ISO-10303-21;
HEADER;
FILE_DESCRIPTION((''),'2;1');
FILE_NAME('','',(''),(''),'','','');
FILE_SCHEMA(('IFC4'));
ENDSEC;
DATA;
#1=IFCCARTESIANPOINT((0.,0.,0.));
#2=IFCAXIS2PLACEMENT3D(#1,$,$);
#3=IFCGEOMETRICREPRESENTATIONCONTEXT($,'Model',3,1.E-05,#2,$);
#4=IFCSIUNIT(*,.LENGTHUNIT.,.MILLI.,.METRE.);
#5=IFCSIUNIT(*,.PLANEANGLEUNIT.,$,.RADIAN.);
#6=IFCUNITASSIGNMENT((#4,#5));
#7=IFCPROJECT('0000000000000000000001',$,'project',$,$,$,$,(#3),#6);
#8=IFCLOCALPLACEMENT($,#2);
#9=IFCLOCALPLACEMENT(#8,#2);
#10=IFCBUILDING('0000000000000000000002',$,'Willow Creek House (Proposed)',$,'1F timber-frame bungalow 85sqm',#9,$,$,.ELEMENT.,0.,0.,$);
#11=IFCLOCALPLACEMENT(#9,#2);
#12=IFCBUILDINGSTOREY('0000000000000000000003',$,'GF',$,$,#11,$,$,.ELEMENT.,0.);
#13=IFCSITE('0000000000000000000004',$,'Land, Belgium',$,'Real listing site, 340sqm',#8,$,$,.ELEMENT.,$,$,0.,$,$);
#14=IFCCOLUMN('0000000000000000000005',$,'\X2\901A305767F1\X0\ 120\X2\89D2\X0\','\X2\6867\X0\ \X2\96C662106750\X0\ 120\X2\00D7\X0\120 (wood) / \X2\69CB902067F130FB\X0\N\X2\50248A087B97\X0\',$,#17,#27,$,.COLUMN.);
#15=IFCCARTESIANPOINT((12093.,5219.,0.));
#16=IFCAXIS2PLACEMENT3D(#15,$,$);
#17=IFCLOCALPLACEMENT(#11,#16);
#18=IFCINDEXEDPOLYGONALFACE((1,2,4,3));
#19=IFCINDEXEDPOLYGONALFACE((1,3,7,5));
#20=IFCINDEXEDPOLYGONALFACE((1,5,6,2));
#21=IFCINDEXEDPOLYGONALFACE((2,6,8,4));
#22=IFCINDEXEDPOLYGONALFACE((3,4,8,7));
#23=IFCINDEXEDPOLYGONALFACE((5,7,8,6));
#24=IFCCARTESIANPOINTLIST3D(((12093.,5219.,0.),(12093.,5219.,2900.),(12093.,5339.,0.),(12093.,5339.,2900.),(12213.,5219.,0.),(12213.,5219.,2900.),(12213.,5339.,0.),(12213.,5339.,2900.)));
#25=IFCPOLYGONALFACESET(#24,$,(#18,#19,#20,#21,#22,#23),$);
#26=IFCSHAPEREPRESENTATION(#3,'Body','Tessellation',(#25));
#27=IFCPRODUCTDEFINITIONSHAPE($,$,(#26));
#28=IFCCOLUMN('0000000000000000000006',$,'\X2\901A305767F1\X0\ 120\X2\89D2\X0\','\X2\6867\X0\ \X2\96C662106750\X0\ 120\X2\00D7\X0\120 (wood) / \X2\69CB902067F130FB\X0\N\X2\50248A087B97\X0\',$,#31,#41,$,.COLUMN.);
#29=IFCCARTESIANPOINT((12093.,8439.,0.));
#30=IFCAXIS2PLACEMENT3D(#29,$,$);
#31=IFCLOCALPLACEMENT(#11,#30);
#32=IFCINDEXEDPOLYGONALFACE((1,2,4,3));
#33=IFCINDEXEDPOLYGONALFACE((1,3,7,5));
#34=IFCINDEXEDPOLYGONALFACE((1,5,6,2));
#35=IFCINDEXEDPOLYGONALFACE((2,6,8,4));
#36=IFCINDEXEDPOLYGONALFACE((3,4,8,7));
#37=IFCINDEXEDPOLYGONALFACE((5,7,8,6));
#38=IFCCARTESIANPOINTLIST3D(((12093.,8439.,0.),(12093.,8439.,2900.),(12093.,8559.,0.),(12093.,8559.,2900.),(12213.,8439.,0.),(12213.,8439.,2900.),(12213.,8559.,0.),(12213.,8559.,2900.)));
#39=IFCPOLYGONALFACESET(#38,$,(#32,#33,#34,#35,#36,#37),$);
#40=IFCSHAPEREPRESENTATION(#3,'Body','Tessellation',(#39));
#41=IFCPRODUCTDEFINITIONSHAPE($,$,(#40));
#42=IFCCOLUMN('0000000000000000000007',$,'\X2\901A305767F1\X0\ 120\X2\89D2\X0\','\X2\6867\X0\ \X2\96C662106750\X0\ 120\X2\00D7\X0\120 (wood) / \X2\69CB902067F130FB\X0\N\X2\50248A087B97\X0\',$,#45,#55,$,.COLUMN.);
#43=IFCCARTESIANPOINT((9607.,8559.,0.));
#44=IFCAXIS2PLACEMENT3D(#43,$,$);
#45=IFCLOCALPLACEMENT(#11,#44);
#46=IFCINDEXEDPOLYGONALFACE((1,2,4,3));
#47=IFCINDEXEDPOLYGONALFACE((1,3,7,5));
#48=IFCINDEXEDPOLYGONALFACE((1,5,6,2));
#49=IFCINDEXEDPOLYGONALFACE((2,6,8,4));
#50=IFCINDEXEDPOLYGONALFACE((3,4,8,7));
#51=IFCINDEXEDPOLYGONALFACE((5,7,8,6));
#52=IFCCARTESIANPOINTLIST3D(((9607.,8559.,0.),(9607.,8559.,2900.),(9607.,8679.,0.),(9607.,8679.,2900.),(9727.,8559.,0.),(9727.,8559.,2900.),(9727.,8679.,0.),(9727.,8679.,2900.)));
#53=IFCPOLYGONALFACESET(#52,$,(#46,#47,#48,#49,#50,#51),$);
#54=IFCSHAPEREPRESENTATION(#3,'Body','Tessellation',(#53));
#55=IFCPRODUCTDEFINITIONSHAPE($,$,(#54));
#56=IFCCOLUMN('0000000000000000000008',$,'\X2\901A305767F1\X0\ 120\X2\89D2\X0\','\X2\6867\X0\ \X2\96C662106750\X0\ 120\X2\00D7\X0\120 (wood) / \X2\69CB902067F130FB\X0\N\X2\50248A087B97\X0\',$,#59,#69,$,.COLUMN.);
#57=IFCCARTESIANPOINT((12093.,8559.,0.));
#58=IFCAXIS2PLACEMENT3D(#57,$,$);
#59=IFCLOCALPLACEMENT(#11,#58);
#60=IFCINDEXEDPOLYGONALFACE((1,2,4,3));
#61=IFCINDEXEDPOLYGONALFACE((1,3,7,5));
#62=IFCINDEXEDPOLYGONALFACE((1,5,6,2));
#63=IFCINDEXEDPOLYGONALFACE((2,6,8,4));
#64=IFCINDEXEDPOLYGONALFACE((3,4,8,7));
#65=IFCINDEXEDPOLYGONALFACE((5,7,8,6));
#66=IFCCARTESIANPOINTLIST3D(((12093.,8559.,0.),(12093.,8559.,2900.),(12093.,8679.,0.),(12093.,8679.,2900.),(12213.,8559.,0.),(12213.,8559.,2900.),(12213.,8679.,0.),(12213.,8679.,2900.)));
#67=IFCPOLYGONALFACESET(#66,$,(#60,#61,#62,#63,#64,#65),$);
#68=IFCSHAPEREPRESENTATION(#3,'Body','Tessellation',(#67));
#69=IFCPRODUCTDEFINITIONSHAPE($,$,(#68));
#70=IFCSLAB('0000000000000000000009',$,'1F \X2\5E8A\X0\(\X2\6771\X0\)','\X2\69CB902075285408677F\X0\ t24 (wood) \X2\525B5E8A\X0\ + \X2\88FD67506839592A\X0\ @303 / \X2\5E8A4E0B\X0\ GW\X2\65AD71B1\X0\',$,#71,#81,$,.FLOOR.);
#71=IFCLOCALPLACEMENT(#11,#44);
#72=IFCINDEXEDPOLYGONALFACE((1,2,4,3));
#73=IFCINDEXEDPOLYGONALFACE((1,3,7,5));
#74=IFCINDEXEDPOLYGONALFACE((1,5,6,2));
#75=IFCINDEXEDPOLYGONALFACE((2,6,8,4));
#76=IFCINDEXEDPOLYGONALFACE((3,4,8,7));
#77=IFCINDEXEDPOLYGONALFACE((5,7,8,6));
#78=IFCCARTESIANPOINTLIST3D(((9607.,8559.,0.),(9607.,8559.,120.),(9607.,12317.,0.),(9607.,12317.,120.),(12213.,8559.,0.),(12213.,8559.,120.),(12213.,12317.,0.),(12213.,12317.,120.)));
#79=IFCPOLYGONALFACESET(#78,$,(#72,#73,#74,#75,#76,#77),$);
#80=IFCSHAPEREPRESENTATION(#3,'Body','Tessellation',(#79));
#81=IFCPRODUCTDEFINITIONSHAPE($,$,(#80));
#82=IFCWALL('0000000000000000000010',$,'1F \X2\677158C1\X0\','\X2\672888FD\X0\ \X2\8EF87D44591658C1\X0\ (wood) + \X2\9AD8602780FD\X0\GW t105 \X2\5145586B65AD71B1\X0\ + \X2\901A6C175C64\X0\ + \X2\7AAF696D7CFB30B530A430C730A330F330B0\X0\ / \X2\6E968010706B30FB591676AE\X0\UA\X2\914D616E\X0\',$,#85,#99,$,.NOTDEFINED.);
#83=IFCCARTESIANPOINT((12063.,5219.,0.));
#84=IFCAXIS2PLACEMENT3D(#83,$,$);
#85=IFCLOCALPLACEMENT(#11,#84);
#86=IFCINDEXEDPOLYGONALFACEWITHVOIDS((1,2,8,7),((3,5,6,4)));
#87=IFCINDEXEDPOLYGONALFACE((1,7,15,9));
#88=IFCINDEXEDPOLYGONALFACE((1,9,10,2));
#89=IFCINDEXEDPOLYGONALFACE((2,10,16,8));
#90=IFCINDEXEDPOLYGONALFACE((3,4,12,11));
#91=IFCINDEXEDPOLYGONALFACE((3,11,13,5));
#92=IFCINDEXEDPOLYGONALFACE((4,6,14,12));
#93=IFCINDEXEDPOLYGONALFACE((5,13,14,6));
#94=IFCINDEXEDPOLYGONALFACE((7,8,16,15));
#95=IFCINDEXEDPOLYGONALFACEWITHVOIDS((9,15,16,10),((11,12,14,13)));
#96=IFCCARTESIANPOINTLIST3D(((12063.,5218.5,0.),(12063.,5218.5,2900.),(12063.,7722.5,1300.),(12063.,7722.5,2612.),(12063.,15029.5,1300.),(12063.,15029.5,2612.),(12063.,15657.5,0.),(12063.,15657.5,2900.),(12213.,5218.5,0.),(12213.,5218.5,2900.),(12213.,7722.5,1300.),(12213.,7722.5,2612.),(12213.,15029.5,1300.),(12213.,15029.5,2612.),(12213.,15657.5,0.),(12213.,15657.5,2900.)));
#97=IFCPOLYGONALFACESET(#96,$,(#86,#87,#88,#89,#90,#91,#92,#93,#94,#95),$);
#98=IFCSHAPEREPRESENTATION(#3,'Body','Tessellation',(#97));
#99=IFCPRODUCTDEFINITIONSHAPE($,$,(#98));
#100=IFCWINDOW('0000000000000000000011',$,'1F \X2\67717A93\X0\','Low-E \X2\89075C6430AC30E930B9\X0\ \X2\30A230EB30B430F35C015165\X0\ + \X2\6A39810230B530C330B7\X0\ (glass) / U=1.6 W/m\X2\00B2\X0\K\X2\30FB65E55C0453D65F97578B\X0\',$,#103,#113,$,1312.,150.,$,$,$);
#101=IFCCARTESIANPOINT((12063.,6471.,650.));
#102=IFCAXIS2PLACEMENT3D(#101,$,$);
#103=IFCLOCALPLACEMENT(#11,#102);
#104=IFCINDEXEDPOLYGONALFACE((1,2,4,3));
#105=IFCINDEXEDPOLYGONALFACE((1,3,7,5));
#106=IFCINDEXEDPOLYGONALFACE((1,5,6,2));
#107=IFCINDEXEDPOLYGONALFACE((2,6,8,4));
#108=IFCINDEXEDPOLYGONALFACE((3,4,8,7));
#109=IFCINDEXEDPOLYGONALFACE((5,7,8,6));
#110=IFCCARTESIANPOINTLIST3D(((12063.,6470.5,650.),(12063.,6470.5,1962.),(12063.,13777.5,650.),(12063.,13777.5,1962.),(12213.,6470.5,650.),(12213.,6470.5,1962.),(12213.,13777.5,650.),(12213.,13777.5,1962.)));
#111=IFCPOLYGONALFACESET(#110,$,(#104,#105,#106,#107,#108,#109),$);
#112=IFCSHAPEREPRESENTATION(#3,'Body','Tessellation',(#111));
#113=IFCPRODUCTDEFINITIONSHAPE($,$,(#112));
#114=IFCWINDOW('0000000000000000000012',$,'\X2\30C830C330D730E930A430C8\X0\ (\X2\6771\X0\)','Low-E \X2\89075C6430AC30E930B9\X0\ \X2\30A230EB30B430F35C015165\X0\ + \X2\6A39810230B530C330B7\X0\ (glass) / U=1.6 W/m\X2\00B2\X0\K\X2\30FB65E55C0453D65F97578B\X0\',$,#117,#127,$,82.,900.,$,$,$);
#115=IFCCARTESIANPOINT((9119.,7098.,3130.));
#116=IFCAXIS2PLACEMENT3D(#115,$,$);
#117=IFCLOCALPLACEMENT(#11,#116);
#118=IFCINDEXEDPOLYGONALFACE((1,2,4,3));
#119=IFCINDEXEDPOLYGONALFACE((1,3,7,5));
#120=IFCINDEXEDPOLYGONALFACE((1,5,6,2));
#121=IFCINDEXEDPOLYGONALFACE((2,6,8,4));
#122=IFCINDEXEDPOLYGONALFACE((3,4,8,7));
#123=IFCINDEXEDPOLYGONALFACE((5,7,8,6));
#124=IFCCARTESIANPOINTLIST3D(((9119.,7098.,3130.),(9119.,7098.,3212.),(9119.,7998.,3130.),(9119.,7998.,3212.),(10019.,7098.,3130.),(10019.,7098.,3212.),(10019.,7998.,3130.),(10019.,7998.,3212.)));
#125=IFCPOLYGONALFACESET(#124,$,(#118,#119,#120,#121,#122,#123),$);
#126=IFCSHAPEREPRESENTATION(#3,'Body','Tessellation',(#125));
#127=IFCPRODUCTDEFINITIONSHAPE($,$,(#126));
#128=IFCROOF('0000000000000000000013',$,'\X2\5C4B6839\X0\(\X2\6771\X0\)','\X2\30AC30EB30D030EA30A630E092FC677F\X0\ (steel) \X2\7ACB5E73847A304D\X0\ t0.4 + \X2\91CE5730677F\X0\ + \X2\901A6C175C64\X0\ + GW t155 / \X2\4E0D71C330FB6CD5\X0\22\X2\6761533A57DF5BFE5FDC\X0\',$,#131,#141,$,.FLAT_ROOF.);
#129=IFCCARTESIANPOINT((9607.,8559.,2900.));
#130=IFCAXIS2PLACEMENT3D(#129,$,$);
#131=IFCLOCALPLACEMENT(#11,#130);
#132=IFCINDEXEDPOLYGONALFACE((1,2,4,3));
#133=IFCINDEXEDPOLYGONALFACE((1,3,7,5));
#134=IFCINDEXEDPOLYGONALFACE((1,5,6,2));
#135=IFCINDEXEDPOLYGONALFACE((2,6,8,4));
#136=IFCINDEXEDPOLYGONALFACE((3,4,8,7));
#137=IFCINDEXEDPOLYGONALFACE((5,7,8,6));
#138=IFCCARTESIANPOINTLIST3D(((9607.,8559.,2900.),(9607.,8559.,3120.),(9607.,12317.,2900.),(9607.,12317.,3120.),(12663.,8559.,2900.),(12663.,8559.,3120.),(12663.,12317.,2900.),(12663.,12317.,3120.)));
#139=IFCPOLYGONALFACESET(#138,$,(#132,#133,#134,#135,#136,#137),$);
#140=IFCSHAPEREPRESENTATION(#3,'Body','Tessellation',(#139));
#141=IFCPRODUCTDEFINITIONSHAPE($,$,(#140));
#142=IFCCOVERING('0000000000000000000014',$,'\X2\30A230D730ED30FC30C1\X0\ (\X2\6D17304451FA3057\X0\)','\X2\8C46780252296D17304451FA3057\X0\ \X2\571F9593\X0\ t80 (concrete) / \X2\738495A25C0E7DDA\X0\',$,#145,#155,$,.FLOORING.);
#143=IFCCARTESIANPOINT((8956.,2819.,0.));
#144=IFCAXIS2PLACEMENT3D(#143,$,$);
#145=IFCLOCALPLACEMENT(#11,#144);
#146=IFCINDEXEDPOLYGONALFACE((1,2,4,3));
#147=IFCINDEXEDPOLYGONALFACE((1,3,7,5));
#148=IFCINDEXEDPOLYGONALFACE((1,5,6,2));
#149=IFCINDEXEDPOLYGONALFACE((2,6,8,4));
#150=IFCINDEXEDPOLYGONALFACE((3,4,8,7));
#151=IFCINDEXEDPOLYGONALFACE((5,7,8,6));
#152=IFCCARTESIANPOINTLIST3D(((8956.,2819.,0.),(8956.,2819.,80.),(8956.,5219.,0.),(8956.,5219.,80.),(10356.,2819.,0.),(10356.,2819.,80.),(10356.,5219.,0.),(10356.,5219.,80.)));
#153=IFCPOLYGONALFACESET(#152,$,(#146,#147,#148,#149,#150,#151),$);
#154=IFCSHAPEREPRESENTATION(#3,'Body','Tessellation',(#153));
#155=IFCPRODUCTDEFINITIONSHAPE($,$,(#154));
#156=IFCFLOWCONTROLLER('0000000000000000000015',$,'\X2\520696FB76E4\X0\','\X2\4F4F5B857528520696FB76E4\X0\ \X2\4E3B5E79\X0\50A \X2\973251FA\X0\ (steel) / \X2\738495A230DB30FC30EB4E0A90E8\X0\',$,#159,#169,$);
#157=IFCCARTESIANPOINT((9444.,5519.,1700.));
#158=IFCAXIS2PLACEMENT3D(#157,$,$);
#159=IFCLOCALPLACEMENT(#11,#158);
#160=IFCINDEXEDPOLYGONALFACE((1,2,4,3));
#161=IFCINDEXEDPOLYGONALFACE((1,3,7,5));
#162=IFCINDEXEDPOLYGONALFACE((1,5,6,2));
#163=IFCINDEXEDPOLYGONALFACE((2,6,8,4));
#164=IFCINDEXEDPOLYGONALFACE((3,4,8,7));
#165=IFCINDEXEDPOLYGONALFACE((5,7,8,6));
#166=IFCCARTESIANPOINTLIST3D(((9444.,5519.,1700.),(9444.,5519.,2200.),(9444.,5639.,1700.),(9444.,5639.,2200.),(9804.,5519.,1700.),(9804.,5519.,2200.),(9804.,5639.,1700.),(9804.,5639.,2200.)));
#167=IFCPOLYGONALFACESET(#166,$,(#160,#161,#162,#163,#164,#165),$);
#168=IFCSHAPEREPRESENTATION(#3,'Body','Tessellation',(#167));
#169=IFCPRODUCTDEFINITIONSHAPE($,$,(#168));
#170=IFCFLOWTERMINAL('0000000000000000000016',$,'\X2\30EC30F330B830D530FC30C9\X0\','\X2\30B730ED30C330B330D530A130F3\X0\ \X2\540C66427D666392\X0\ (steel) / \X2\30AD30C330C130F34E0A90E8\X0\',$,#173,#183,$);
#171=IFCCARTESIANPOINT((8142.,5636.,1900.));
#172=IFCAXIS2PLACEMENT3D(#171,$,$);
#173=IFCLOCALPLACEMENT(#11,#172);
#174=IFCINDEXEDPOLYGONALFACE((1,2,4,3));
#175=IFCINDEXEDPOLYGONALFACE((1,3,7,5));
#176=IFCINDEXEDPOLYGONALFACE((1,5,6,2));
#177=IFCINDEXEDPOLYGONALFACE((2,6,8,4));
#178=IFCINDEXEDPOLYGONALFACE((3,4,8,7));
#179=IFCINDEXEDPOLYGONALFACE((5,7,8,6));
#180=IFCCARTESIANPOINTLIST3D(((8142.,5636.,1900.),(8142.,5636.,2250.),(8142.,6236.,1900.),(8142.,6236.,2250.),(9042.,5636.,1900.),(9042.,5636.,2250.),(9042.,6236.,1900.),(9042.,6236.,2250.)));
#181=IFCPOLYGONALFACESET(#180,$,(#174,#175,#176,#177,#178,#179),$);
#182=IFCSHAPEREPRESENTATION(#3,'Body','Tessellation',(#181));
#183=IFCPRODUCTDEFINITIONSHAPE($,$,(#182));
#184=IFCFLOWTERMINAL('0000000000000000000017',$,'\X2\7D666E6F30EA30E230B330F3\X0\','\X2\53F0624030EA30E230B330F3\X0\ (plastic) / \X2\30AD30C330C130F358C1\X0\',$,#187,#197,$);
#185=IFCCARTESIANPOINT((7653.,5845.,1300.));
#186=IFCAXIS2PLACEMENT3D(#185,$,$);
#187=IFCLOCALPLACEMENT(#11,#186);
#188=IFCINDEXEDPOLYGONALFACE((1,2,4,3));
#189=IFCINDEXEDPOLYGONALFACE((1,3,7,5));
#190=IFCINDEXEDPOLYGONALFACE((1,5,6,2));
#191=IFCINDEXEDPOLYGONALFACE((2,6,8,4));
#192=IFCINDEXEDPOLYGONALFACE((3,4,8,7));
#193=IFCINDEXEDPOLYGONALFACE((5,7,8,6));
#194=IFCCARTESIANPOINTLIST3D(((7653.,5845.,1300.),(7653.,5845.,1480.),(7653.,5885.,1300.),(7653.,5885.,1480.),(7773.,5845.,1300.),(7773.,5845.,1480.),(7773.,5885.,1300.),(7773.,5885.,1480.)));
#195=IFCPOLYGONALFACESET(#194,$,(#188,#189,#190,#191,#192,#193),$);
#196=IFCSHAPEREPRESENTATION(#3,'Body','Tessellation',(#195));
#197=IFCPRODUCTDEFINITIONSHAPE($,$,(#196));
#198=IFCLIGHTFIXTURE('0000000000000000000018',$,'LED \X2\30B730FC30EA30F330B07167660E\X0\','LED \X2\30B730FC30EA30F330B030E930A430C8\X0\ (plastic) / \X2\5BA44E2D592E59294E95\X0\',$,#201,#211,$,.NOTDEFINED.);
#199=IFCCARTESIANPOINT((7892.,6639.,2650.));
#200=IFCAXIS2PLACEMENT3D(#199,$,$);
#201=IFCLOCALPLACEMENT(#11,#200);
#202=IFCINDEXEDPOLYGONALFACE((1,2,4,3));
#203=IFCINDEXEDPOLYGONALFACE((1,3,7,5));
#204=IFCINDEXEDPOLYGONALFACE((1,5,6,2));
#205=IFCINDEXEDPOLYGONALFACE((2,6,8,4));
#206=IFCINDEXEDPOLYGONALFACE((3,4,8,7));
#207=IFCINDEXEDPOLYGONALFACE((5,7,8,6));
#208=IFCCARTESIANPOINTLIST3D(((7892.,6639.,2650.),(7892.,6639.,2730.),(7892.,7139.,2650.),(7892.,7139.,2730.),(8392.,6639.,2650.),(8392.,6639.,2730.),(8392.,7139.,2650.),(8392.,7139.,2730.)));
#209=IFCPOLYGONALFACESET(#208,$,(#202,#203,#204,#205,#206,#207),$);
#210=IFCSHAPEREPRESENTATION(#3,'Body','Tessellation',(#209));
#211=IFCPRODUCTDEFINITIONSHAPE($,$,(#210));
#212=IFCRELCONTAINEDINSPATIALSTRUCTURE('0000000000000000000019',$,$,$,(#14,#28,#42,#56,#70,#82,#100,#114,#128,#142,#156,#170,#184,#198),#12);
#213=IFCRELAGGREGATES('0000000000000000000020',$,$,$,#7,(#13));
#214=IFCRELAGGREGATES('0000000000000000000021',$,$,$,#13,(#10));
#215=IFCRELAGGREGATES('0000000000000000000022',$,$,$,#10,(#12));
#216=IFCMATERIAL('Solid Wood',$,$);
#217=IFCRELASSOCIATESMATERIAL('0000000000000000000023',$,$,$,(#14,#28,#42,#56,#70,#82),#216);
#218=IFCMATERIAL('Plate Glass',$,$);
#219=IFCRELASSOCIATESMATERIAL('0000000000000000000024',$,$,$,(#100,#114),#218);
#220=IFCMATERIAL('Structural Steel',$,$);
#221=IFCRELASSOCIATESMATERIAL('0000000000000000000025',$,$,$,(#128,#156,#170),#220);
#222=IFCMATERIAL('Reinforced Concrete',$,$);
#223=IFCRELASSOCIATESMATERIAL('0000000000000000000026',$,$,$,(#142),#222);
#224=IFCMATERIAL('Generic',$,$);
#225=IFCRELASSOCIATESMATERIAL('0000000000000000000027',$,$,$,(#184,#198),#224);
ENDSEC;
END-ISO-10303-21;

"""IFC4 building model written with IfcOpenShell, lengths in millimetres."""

from ifc_helpers import new_model, si_unit, frame, frame_2d, origin, place, context, project, spatial, rectangle, extrude, material, element, fill, save


model = new_model("IFC4")

# Units and contexts
model_context = context("Model", 3, precision=1e-05, world=origin())
ifc_project = project(units=[si_unit("LENGTHUNIT", "METRE", prefix="MILLI"), si_unit("PLANEANGLEUNIT", "RADIAN")], contexts=[model_context])

# Site, building, storey
site_placement = place(None, origin())
site = spatial("IfcSite", under=ifc_project, at=site_placement, Name="Land, Belgium", ObjectType="Real listing site, 340sqm", CompositionType="ELEMENT", RefElevation=0.0)
building_placement = place(site_placement, origin())
building = spatial("IfcBuilding", under=site, at=building_placement, Name="Willow Creek House (Proposed)", ObjectType="1F timber-frame bungalow 85sqm", CompositionType="ELEMENT", ElevationOfRefHeight=0.0, ElevationOfTerrain=0.0)
storey_placement = place(building_placement, origin())
storey = spatial("IfcBuildingStorey", under=building, at=storey_placement, Name="GF", CompositionType="ELEMENT", Elevation=0.0)

# Columns
ifc_material_1 = material(Name="Solid Wood")
column_1_placement = place(storey_placement, frame((12093.0, 5219.0, 0.0)))
element("IfcColumn", 1, at=column_1_placement, inside=storey, material=ifc_material_1, Name="通し柱 120角", Description="桧 集成材 120×120 (wood) / 構造柱・N値計算", PredefinedType="COLUMN", context=model_context, shape_type="SweptSolid", body=[
    extrude(rectangle(XDim=120.0, YDim=120.0, at=frame_2d((60.0, 60.0))), frame((12093.0, 5219.0, 0.0)), (0.0, 0.0, 1.0), 2900.0),
])
column_2_placement = place(storey_placement, frame((12093.0, 8439.0, 0.0)))
element("IfcColumn", 2, at=column_2_placement, inside=storey, material=ifc_material_1, Name="通し柱 120角", Description="桧 集成材 120×120 (wood) / 構造柱・N値計算", PredefinedType="COLUMN", context=model_context, shape_type="SweptSolid", body=[
    extrude(rectangle(XDim=120.0, YDim=120.0, at=frame_2d((60.0, 60.0))), frame((12093.0, 8439.0, 0.0)), (0.0, 0.0, 1.0), 2900.0),
])
column_3_placement = place(storey_placement, frame((9607.0, 8559.0, 0.0)))
element("IfcColumn", 3, at=column_3_placement, inside=storey, material=ifc_material_1, Name="通し柱 120角", Description="桧 集成材 120×120 (wood) / 構造柱・N値計算", PredefinedType="COLUMN", context=model_context, shape_type="SweptSolid", body=[
    extrude(rectangle(XDim=120.0, YDim=120.0, at=frame_2d((60.0, 60.0))), frame((9607.0, 8559.0, 0.0)), (0.0, 0.0, 1.0), 2900.0),
])
column_4_placement = place(storey_placement, frame((12093.0, 8559.0, 0.0)))
element("IfcColumn", 4, at=column_4_placement, inside=storey, material=ifc_material_1, Name="通し柱 120角", Description="桧 集成材 120×120 (wood) / 構造柱・N値計算", PredefinedType="COLUMN", context=model_context, shape_type="SweptSolid", body=[
    extrude(rectangle(XDim=120.0, YDim=120.0, at=frame_2d((60.0, 60.0))), frame((12093.0, 8559.0, 0.0)), (0.0, 0.0, 1.0), 2900.0),
])

# Slab
slab_placement = place(storey_placement, frame((9607.0, 8559.0, 0.0)))
element("IfcSlab", 5, at=slab_placement, inside=storey, material=ifc_material_1, Name="1F 床(東)", Description="構造用合板 t24 (wood) 剛床 + 製材根太 @303 / 床下 GW断熱", PredefinedType="FLOOR", context=model_context, shape_type="SweptSolid", body=[
    extrude(rectangle(XDim=2606.0, YDim=3758.0, at=frame_2d((1303.0, 1879.0))), frame((9607.0, 8559.0, 0.0)), (0.0, 0.0, 1.0), 120.0),
])

# Wall, opening, window
wall_1_placement = place(storey_placement, frame((12063.0, 5219.0, 0.0)))
wall_1 = element("IfcWall", 6, at=wall_1_placement, inside=storey, material=ifc_material_1, Name="1F 東壁", Description="木製 軸組外壁 (wood) + 高性能GW t105 充填断熱 + 通気層 + 窯業系サイディング / 準耐火・外皮UA配慮", PredefinedType="NOTDEFINED", context=model_context, shape_type="SweptSolid", body=[
    extrude(rectangle(XDim=150.0, YDim=10439.0, at=frame_2d((75.0, 5219.0))), frame((12063.0, 5219.0, 0.0)), (0.0, 0.0, 1.0), 2900.0),
])
opening_placement = place(storey_placement, frame((12063.0, 6471.0, 650.0)))
opening = element("IfcOpeningElement", 7, at=opening_placement, cuts=wall_1, PredefinedType="NOTDEFINED", context=model_context, shape_type="SweptSolid", body=[
    extrude(rectangle(XDim=150.0, YDim=7307.0, at=frame_2d((75.0, 3653.0))), frame((12063.0, 6471.0, 650.0)), (0.0, 0.0, 1.0), 1312.0),
])
ifc_material_2 = material(Name="Plate Glass")
window_1_placement = place(storey_placement, frame((12063.0, 6471.0, 650.0)))
window_1 = element("IfcWindow", 8, at=window_1_placement, inside=storey, material=ifc_material_2, Name="1F 東窓", Description="Low-E 複層ガラス アルゴン封入 + 樹脂サッシ (glass) / U=1.6 W/m²K・日射取得型", OverallHeight=1312.0, OverallWidth=150.0, context=model_context, shape_type="SweptSolid", body=[
    extrude(rectangle(XDim=150.0, YDim=7307.0, at=frame_2d((75.0, 3653.0))), frame((12063.0, 6471.0, 650.0)), (0.0, 0.0, 1.0), 1312.0),
])
fill(opening, window_1)

# Window
window_2_placement = place(storey_placement, frame((9119.0, 7098.0, 3130.0)))
element("IfcWindow", 9, at=window_2_placement, inside=storey, material=ifc_material_2, Name="トップライト (東)", Description="Low-E 複層ガラス アルゴン封入 + 樹脂サッシ (glass) / U=1.6 W/m²K・日射取得型", OverallHeight=82.0, OverallWidth=900.0, context=model_context, shape_type="SweptSolid", body=[
    extrude(rectangle(XDim=900.0, YDim=900.0, at=frame_2d((450.0, 450.0))), frame((9119.0, 7098.0, 3130.0)), (0.0, 0.0, 1.0), 82.0),
])

# Roof
ifc_material_3 = material(Name="Structural Steel")
roof_placement = place(storey_placement, frame((9607.0, 8559.0, 2900.0)))
element("IfcRoof", 10, at=roof_placement, inside=storey, material=ifc_material_3, Name="屋根(東)", Description="ガルバリウム鋼板 (steel) 立平葺き t0.4 + 野地板 + 通気層 + GW t155 / 不燃・法22条区域対応", PredefinedType="FLAT_ROOF", context=model_context, shape_type="SweptSolid", body=[
    extrude(rectangle(XDim=3056.0, YDim=3758.0, at=frame_2d((1528.0, 1879.0))), frame((9607.0, 8559.0, 2900.0)), (0.0, 0.0, 1.0), 220.0),
])

# Covering
ifc_material_4 = material(Name="Reinforced Concrete")
covering_placement = place(storey_placement, frame((8956.0, 2819.0, 0.0)))
element("IfcCovering", 11, at=covering_placement, inside=storey, material=ifc_material_4, Name="アプローチ (洗い出し)", Description="豆砂利洗い出し 土間 t80 (concrete) / 玄関導線", PredefinedType="FLOORING", context=model_context, shape_type="SweptSolid", body=[
    extrude(rectangle(XDim=1400.0, YDim=2400.0, at=frame_2d((700.0, 1200.0))), frame((8956.0, 2819.0, 0.0)), (0.0, 0.0, 1.0), 80.0),
])

# Flow controller
flow_controller_placement = place(storey_placement, frame((9444.0, 5519.0, 1700.0)))
element("IfcFlowController", 12, at=flow_controller_placement, inside=storey, material=ifc_material_3, Name="分電盤", Description="住宅用分電盤 主幹50A 露出 (steel) / 玄関ホール上部", context=model_context, shape_type="SweptSolid", body=[
    extrude(rectangle(XDim=360.0, YDim=120.0, at=frame_2d((180.0, 60.0))), frame((9444.0, 5519.0, 1700.0)), (0.0, 0.0, 1.0), 500.0),
])

# Flow terminals
flow_terminal_1_placement = place(storey_placement, frame((8142.0, 5636.0, 1900.0)))
element("IfcFlowTerminal", 13, at=flow_terminal_1_placement, inside=storey, material=ifc_material_3, Name="レンジフード", Description="シロッコファン 同時給排 (steel) / キッチン上部", context=model_context, shape_type="SweptSolid", body=[
    extrude(rectangle(XDim=900.0, YDim=600.0, at=frame_2d((450.0, 300.0))), frame((8142.0, 5636.0, 1900.0)), (0.0, 0.0, 1.0), 350.0),
])
ifc_material_5 = material(Name="Generic")
flow_terminal_2_placement = place(storey_placement, frame((7653.0, 5845.0, 1300.0)))
element("IfcFlowTerminal", 14, at=flow_terminal_2_placement, inside=storey, material=ifc_material_5, Name="給湯リモコン", Description="台所リモコン (plastic) / キッチン壁", context=model_context, shape_type="SweptSolid", body=[
    extrude(rectangle(XDim=120.0, YDim=40.0, at=frame_2d((60.0, 20.0))), frame((7653.0, 5845.0, 1300.0)), (0.0, 0.0, 1.0), 180.0),
])

# Light fixture
light_fixture_placement = place(storey_placement, frame((7892.0, 6639.0, 2650.0)))
element("IfcLightFixture", 15, at=light_fixture_placement, inside=storey, material=ifc_material_5, Name="LED シーリング照明", Description="LED シーリングライト (plastic) / 室中央天井", PredefinedType="NOTDEFINED", context=model_context, shape_type="SweptSolid", body=[
    extrude(rectangle(XDim=500.0, YDim=500.0, at=frame_2d((250.0, 250.0))), frame((7892.0, 6639.0, 2650.0)), (0.0, 0.0, 1.0), 80.0),
])

save(model, "model.ifc")
